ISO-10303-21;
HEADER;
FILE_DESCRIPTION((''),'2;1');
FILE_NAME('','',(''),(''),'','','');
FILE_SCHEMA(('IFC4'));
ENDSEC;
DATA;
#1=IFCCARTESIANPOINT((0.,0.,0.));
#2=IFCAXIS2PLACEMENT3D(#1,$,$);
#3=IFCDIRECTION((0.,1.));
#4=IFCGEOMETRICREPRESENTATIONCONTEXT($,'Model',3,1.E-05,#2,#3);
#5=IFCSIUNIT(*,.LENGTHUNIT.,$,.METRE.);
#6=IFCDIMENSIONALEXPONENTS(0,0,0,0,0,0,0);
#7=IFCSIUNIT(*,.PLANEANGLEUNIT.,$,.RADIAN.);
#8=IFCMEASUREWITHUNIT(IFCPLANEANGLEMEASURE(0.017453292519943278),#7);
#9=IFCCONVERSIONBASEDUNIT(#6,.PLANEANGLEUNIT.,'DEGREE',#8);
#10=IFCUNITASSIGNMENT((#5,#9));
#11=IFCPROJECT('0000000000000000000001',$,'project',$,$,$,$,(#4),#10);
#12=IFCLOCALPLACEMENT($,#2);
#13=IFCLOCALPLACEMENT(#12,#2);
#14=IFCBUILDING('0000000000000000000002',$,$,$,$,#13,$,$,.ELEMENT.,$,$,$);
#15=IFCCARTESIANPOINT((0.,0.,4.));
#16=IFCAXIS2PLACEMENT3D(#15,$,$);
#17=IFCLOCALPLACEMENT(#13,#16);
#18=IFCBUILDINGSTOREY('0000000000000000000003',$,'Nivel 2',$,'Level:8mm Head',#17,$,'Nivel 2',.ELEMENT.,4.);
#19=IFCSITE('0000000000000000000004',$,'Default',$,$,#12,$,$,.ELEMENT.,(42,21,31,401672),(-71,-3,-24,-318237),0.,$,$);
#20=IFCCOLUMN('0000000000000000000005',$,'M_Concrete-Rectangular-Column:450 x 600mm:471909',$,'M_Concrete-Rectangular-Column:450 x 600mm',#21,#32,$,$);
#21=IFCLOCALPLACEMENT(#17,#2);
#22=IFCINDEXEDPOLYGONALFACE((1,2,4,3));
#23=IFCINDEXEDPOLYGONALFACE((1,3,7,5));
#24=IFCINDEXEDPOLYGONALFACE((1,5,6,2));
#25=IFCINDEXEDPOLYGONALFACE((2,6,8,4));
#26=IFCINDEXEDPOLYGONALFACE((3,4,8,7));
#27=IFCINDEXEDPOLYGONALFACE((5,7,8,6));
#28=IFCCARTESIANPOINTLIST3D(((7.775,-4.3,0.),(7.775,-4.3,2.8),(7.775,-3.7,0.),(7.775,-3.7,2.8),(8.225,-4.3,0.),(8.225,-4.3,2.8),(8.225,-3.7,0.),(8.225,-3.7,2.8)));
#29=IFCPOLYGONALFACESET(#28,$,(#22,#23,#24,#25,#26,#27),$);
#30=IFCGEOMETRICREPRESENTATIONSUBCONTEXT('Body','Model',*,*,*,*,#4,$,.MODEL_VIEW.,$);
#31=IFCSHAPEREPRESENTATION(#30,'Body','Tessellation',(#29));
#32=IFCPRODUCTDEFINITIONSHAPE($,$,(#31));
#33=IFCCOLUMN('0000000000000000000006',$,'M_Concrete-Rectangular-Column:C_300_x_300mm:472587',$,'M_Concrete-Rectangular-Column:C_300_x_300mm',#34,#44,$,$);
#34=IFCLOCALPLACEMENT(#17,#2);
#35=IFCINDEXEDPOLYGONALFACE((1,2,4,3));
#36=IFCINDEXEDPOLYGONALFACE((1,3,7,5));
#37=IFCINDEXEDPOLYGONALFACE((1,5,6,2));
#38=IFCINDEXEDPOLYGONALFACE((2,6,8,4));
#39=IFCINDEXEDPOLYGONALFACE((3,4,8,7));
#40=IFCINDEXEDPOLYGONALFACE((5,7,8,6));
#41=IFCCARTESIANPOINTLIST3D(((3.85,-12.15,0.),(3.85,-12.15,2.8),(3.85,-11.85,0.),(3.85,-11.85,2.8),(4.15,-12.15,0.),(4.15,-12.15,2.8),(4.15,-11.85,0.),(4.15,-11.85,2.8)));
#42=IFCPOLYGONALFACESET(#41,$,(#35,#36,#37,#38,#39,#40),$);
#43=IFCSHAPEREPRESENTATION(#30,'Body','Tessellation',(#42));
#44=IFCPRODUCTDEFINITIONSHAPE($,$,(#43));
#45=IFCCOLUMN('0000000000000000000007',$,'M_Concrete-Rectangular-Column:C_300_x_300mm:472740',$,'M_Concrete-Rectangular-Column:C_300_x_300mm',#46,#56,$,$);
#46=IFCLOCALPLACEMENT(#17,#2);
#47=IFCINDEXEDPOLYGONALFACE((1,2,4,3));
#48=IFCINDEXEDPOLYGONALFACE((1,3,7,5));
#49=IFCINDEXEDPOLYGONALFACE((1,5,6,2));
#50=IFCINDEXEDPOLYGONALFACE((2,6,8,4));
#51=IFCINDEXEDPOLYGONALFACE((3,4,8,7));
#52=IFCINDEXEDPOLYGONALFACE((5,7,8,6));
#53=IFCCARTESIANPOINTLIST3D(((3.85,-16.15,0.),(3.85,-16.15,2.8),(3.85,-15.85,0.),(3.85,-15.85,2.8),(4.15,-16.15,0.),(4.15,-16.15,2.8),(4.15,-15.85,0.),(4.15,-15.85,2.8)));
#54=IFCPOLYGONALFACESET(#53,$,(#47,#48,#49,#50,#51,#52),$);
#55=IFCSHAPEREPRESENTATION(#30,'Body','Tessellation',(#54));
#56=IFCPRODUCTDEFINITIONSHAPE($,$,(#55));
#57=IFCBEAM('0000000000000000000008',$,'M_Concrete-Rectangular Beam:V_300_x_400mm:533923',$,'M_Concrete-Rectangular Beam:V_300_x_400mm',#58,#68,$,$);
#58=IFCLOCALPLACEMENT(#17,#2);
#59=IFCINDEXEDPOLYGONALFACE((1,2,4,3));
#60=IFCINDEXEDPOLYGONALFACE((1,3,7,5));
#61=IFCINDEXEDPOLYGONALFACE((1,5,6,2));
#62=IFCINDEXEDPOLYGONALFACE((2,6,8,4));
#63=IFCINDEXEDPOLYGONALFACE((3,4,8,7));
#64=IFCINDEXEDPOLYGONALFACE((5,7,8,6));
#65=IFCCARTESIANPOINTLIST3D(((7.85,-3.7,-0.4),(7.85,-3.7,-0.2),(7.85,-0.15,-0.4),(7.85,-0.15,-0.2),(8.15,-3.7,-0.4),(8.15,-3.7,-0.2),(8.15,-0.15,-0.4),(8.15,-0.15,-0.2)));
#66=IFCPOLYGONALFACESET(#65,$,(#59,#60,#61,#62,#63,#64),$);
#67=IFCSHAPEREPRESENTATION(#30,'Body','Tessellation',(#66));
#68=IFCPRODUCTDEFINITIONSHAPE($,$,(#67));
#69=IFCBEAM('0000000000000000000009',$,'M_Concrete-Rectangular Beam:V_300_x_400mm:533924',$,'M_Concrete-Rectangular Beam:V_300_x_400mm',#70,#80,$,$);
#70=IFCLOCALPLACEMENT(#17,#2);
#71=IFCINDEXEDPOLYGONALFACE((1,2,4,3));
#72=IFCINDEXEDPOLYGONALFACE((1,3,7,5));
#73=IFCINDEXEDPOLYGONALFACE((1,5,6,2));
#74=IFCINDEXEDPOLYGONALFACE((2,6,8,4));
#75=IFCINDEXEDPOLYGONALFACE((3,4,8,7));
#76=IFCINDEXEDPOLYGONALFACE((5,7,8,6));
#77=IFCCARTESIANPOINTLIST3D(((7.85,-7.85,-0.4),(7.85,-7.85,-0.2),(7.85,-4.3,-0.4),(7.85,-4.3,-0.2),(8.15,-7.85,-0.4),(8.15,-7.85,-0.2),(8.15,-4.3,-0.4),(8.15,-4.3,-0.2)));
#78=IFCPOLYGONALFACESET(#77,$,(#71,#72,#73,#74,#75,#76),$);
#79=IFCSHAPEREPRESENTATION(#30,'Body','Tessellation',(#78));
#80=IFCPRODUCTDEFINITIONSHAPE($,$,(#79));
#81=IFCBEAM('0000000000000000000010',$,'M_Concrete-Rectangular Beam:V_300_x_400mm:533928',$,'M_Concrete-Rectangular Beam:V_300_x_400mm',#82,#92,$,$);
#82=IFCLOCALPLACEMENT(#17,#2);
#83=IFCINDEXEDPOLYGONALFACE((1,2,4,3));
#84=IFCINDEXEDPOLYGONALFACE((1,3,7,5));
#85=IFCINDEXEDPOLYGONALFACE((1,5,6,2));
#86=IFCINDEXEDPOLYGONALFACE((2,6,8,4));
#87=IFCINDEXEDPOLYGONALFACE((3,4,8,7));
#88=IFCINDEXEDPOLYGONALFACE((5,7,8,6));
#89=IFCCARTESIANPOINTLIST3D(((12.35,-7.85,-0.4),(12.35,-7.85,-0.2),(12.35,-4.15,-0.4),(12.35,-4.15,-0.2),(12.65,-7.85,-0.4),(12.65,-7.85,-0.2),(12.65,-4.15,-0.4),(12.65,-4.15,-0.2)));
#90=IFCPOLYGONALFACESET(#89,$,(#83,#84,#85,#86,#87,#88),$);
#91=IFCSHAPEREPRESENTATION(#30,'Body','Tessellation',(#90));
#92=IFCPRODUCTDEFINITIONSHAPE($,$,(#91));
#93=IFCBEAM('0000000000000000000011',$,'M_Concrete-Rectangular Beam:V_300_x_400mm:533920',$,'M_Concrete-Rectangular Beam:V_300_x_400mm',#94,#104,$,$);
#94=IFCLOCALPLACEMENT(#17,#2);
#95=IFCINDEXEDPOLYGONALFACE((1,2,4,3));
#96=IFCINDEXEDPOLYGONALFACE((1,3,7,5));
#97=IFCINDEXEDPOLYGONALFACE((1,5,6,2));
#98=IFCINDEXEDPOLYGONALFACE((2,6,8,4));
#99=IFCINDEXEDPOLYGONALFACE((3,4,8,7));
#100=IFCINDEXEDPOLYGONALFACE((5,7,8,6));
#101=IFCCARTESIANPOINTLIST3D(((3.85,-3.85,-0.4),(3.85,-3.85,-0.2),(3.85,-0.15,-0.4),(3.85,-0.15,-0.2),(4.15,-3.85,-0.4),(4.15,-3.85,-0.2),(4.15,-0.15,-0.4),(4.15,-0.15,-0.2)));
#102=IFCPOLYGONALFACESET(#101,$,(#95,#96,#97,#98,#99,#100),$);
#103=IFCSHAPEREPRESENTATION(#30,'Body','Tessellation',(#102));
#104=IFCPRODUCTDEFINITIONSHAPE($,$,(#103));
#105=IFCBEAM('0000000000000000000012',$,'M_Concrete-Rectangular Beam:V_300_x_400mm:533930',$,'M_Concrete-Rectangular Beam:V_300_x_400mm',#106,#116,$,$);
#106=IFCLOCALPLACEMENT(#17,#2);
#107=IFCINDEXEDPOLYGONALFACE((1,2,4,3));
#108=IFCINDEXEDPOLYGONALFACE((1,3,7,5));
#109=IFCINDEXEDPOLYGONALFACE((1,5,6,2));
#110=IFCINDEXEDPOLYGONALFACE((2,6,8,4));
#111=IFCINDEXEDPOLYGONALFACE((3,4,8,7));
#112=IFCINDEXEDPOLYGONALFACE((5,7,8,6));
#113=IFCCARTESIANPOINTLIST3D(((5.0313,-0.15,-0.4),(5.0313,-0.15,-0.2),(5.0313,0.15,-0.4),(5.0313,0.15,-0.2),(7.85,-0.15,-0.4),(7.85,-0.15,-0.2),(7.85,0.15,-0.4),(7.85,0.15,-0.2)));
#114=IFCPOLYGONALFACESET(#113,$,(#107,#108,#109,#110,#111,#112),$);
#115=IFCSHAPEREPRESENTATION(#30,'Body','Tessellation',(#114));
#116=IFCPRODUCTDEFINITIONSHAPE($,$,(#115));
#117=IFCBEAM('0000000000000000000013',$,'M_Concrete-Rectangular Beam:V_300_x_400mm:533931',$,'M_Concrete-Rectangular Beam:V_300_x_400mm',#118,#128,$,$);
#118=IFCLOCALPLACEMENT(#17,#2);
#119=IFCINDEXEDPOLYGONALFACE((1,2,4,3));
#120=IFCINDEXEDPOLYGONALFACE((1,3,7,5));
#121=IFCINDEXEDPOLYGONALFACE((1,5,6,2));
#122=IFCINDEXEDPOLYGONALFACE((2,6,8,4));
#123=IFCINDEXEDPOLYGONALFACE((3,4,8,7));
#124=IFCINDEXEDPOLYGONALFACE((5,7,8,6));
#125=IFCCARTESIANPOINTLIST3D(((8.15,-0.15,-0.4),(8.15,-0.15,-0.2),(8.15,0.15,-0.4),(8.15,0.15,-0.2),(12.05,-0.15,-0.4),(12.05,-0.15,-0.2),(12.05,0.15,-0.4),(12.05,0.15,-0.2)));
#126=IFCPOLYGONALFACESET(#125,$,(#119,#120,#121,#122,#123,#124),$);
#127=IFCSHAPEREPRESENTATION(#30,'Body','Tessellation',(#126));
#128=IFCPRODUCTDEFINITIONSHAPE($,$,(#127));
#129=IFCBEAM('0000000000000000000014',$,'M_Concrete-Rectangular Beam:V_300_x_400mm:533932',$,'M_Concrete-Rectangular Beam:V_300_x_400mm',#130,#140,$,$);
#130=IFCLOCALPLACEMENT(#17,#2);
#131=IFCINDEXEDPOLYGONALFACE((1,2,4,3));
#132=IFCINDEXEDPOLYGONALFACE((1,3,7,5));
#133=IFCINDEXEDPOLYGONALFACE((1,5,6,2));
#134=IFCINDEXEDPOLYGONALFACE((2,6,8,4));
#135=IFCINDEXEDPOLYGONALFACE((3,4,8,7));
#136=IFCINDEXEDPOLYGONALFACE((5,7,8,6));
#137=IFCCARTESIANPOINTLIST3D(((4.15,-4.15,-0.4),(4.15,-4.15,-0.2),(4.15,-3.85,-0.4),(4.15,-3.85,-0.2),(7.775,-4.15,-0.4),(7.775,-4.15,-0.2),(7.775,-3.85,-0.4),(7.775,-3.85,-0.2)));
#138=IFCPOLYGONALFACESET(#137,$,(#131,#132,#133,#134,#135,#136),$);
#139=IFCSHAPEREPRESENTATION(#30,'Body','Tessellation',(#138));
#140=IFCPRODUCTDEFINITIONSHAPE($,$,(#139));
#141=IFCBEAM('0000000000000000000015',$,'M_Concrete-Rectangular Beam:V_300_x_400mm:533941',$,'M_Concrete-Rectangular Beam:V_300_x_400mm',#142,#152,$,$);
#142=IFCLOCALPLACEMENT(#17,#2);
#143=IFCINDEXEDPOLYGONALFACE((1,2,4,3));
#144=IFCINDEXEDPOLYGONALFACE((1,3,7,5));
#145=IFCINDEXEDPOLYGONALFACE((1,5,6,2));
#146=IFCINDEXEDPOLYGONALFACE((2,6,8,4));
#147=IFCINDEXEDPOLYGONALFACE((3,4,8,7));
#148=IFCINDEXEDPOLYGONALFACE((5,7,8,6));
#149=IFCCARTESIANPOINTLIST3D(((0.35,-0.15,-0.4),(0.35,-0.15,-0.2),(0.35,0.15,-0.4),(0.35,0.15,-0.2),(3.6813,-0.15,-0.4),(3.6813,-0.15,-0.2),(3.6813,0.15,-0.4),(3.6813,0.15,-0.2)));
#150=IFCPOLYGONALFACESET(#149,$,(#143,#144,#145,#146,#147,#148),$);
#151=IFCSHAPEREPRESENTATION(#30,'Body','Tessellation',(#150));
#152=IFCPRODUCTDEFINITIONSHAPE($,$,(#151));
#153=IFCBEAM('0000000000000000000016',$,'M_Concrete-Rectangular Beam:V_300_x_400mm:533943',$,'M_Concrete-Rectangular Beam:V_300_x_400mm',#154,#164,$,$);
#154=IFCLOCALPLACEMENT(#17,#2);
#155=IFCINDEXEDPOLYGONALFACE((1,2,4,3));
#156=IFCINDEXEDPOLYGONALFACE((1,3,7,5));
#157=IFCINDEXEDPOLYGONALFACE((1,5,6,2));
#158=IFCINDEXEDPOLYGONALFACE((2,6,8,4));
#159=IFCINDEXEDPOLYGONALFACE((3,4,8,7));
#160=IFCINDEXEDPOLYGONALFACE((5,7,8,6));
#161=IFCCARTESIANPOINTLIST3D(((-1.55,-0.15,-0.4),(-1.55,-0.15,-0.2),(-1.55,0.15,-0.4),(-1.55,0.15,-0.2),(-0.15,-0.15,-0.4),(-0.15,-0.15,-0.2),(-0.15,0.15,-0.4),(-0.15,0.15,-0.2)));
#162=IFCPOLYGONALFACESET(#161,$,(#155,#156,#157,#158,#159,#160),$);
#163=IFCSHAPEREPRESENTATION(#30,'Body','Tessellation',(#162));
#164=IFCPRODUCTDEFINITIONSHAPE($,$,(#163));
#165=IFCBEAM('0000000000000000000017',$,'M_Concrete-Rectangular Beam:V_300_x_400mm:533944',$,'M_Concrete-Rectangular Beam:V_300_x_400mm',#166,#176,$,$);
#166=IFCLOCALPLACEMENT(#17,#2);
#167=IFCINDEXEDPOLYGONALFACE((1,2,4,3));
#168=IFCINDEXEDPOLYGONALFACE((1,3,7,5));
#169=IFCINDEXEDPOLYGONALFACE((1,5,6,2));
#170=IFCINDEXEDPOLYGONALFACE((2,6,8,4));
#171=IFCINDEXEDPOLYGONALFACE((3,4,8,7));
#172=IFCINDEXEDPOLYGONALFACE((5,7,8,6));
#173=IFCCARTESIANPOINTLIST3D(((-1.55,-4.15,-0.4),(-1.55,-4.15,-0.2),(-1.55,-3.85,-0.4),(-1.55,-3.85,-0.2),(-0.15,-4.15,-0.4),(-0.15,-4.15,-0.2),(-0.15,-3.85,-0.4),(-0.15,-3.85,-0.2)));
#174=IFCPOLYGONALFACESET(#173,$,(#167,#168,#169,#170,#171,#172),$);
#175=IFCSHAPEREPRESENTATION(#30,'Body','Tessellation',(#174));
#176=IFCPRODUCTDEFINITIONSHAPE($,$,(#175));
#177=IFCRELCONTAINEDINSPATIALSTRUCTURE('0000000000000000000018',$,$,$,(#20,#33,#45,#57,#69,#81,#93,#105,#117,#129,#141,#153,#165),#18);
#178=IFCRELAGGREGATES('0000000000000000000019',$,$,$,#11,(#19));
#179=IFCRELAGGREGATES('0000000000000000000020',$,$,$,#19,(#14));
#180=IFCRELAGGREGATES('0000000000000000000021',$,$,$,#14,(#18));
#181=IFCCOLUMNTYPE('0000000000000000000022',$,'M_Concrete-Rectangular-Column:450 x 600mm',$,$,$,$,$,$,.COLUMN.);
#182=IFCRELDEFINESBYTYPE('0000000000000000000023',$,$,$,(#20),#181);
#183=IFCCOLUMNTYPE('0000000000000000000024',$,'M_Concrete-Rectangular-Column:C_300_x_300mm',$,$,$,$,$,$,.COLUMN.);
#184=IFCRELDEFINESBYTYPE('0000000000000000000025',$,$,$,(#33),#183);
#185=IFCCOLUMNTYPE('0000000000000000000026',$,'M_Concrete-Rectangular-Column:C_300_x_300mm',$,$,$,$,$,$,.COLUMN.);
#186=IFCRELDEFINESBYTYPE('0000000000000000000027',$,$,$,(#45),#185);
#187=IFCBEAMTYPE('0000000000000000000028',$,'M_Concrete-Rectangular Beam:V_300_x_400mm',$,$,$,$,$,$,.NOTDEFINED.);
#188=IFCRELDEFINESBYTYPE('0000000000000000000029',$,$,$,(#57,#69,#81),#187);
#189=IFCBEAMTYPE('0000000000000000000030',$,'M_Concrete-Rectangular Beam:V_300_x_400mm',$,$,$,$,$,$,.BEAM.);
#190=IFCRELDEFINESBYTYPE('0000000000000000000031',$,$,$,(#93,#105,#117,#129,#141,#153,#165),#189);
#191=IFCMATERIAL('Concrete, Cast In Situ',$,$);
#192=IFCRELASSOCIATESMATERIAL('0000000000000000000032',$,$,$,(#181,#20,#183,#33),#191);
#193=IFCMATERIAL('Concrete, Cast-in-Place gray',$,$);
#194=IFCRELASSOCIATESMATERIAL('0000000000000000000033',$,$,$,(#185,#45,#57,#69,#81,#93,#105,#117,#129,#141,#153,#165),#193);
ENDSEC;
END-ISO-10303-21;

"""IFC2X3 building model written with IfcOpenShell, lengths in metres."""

from ifc_helpers import new_model, entity, si_unit, converted_unit, direction, frame, frame_2d, origin, place, context, subcontext, project, spatial, rectangle, extrude, source, transform, mapped, material, type_object, type_shapes, element, save


model = new_model("IFC2X3")

# Units and contexts
model_context = context("Model", 3, precision=1e-05, world=origin(), true_north=direction((0.0, 1.0)))
body_context = subcontext(model_context, "Body", "Model", "MODEL_VIEW")
ifc_project = project(units=[si_unit("LENGTHUNIT", "METRE"), converted_unit("PLANEANGLEUNIT", "DEGREE", entity("IfcPlaneAngleMeasure", 0.017453292519943278), si_unit("PLANEANGLEUNIT", "RADIAN"), dimensions=[0, 0, 0, 0, 0, 0, 0])], contexts=[model_context])

# Site, building, storey
site_placement = place(None, origin())
site = spatial("IfcSite", under=ifc_project, at=site_placement, Name="Default", CompositionType="ELEMENT", RefLatitude=(42, 21, 31, 401672), RefLongitude=(-71, -3, -24, -318237), RefElevation=0.0)
building_placement = place(site_placement, origin())
building = spatial("IfcBuilding", under=site, at=building_placement, CompositionType="ELEMENT")
storey_placement = place(building_placement, frame((0.0, 0.0, 4.0)))
storey = spatial("IfcBuildingStorey", under=building, at=storey_placement, Name="Nivel 2", ObjectType="Level:8mm Head", LongName="Nivel 2", CompositionType="ELEMENT", Elevation=4.0)

# Columns
ifc_material_1 = material(Name="Concrete, Cast-in-Place gray")
ifc_material_2 = material(Name="Concrete, Cast In Situ")
column_type_1 = type_object("IfcColumnType", Name="M_Concrete-Rectangular-Column:450 x 600mm", PredefinedType="COLUMN", material=ifc_material_2)
shared_shape_1 = source(origin(), body_context, "Body", "SweptSolid", [
    extrude(rectangle(XDim=2.8, YDim=0.6, at=frame_2d((0.0, 0.0), x_axis=(1.0, 0.0))), frame((7.775, -4.0, 5.4), z_axis=(1.0, 0.0, 0.0), x_axis=(0.0, 0.0, 1.0)), (0.0, 0.0, 1.0), 0.45),
])
type_shapes(column_type_1, [shared_shape_1])
column_1_placement = place(storey_placement, frame((0.0, 0.0, -4.0)))
element("IfcColumn", 1, at=column_1_placement, inside=storey, type_object=column_type_1, material=ifc_material_2, Name="M_Concrete-Rectangular-Column:450 x 600mm:471909", ObjectType="M_Concrete-Rectangular-Column:450 x 600mm", context=body_context, shape_type="MappedRepresentation", body=[
    mapped(shared_shape_1, transform((0.0, 0.0, 0.0), scale=1.0)),
])
column_type_2 = type_object("IfcColumnType", Name="M_Concrete-Rectangular-Column:C_300_x_300mm", PredefinedType="COLUMN", material=ifc_material_2)
shared_shape_2 = source(origin(), body_context, "Body", "SweptSolid", [
    extrude(rectangle(XDim=0.3, YDim=0.3, at=frame_2d((0.0, 0.0), x_axis=(1.0, 0.0))), frame((4.0, -12.0, 4.0), z_axis=(0.0, 0.0, 1.0), x_axis=(-1.0, 0.0, 0.0)), (0.0, 0.0, 1.0), 2.8),
])
type_shapes(column_type_2, [shared_shape_2])
column_2_placement = place(storey_placement, frame((0.0, 0.0, -4.0)))
element("IfcColumn", 2, at=column_2_placement, inside=storey, type_object=column_type_2, material=ifc_material_2, Name="M_Concrete-Rectangular-Column:C_300_x_300mm:472587", ObjectType="M_Concrete-Rectangular-Column:C_300_x_300mm", context=body_context, shape_type="MappedRepresentation", body=[
    mapped(shared_shape_2, transform((0.0, 0.0, 0.0), scale=1.0)),
])
column_type_3 = type_object("IfcColumnType", Name="M_Concrete-Rectangular-Column:C_300_x_300mm", PredefinedType="COLUMN", material=ifc_material_1)
shared_shape_3 = source(origin(), body_context, "Body", "SweptSolid", [
    extrude(rectangle(XDim=0.3, YDim=0.3, at=frame_2d((0.0, 0.0), x_axis=(1.0, 0.0))), frame((4.0, -16.0, 4.0), z_axis=(0.0, 0.0, 1.0), x_axis=(-1.0, 0.0, 0.0)), (0.0, 0.0, 1.0), 2.8),
])
type_shapes(column_type_3, [shared_shape_3])
column_3_placement = place(storey_placement, frame((0.0, 0.0, -4.0)))
element("IfcColumn", 3, at=column_3_placement, inside=storey, type_object=column_type_3, material=ifc_material_1, Name="M_Concrete-Rectangular-Column:C_300_x_300mm:472740", ObjectType="M_Concrete-Rectangular-Column:C_300_x_300mm", context=body_context, shape_type="MappedRepresentation", body=[
    mapped(shared_shape_3, transform((0.0, 0.0, 0.0), scale=1.0)),
])

# Beams
beam_type_1 = type_object("IfcBeamType", Name="M_Concrete-Rectangular Beam:V_300_x_400mm", PredefinedType="NOTDEFINED")
beam_1_placement = place(storey_placement, frame((8.0, 0.0, 0.0), z_axis=(0.0, 0.0, 1.0), x_axis=(0.0, -1.0, 0.0)))
element("IfcBeam", 4, at=beam_1_placement, inside=storey, type_object=beam_type_1, material=ifc_material_1, Name="M_Concrete-Rectangular Beam:V_300_x_400mm:533923", ObjectType="M_Concrete-Rectangular Beam:V_300_x_400mm", context=body_context, shape_type="SweptSolid", body=[
    extrude(rectangle(XDim=0.2, YDim=0.3, at=frame_2d((0.0, 0.0), x_axis=(1.0, 0.0))), frame((0.15, 0.0, -0.3), z_axis=(1.0, 0.0, 0.0), x_axis=(0.0, 0.0, -1.0)), (0.0, 0.0, 1.0), 3.55),
])
beam_2_placement = place(storey_placement, frame((8.0, -4.0, 0.0), z_axis=(0.0, 0.0, 1.0), x_axis=(0.0, -1.0, 0.0)))
element("IfcBeam", 5, at=beam_2_placement, inside=storey, type_object=beam_type_1, material=ifc_material_1, Name="M_Concrete-Rectangular Beam:V_300_x_400mm:533924", ObjectType="M_Concrete-Rectangular Beam:V_300_x_400mm", context=body_context, shape_type="SweptSolid", body=[
    extrude(rectangle(XDim=0.2, YDim=0.3, at=frame_2d((0.0, 0.0), x_axis=(1.0, 0.0))), frame((0.3, 0.0, -0.3), z_axis=(1.0, 0.0, 0.0), x_axis=(0.0, 0.0, -1.0)), (0.0, 0.0, 1.0), 3.55),
])
beam_3_placement = place(storey_placement, frame((12.5, -4.0, 0.0), z_axis=(0.0, 0.0, 1.0), x_axis=(0.0, -1.0, 0.0)))
element("IfcBeam", 6, at=beam_3_placement, inside=storey, type_object=beam_type_1, material=ifc_material_1, Name="M_Concrete-Rectangular Beam:V_300_x_400mm:533928", ObjectType="M_Concrete-Rectangular Beam:V_300_x_400mm", context=body_context, shape_type="SweptSolid", body=[
    extrude(rectangle(XDim=0.2, YDim=0.3, at=frame_2d((0.0, 0.0), x_axis=(1.0, 0.0))), frame((0.15, 0.0, -0.3), z_axis=(1.0, 0.0, 0.0), x_axis=(0.0, 0.0, -1.0)), (0.0, 0.0, 1.0), 3.7),
])
beam_type_2 = type_object("IfcBeamType", Name="M_Concrete-Rectangular Beam:V_300_x_400mm", PredefinedType="BEAM")
beam_4_placement = place(storey_placement, frame((4.0, 0.0, 0.0), z_axis=(0.0, 0.0, 1.0), x_axis=(0.0, -1.0, 0.0)))
element("IfcBeam", 7, at=beam_4_placement, inside=storey, type_object=beam_type_2, material=ifc_material_1, Name="M_Concrete-Rectangular Beam:V_300_x_400mm:533920", ObjectType="M_Concrete-Rectangular Beam:V_300_x_400mm", context=body_context, shape_type="SweptSolid", body=[
    extrude(rectangle(XDim=0.2, YDim=0.3, at=frame_2d((0.0, 0.0), x_axis=(1.0, 0.0))), frame((0.15, 0.0, -0.3), z_axis=(1.0, 0.0, 0.0), x_axis=(0.0, 0.0, -1.0)), (0.0, 0.0, 1.0), 3.7),
])
beam_5_placement = place(storey_placement, frame((5.0313, 0.0, 0.0)))
element("IfcBeam", 8, at=beam_5_placement, inside=storey, type_object=beam_type_2, material=ifc_material_1, Name="M_Concrete-Rectangular Beam:V_300_x_400mm:533930", ObjectType="M_Concrete-Rectangular Beam:V_300_x_400mm", context=body_context, shape_type="SweptSolid", body=[
    extrude(rectangle(XDim=0.2, YDim=0.3, at=frame_2d((0.0, 0.0), x_axis=(1.0, 0.0))), frame((0.0, 0.0, -0.3), z_axis=(1.0, 0.0, 0.0), x_axis=(0.0, 0.0, -1.0)), (0.0, 0.0, 1.0), 2.8187),
])
beam_6_placement = place(storey_placement, frame((8.0, 0.0, 0.0)))
element("IfcBeam", 9, at=beam_6_placement, inside=storey, type_object=beam_type_2, material=ifc_material_1, Name="M_Concrete-Rectangular Beam:V_300_x_400mm:533931", ObjectType="M_Concrete-Rectangular Beam:V_300_x_400mm", context=body_context, shape_type="SweptSolid", body=[
    extrude(rectangle(XDim=0.2, YDim=0.3, at=frame_2d((0.0, 0.0), x_axis=(1.0, 0.0))), frame((0.15, 0.0, -0.3), z_axis=(1.0, 0.0, 0.0), x_axis=(0.0, 0.0, -1.0)), (0.0, 0.0, 1.0), 3.9),
])
beam_7_placement = place(storey_placement, frame((4.0, -4.0, 0.0)))
element("IfcBeam", 10, at=beam_7_placement, inside=storey, type_object=beam_type_2, material=ifc_material_1, Name="M_Concrete-Rectangular Beam:V_300_x_400mm:533932", ObjectType="M_Concrete-Rectangular Beam:V_300_x_400mm", context=body_context, shape_type="SweptSolid", body=[
    extrude(rectangle(XDim=0.2, YDim=0.3, at=frame_2d((0.0, 0.0), x_axis=(1.0, 0.0))), frame((0.15, 0.0, -0.3), z_axis=(1.0, 0.0, 0.0), x_axis=(0.0, 0.0, -1.0)), (0.0, 0.0, 1.0), 3.625),
])
beam_8_placement = place(storey_placement, frame((-0.05, 0.0, 0.0)))
element("IfcBeam", 11, at=beam_8_placement, inside=storey, type_object=beam_type_2, material=ifc_material_1, Name="M_Concrete-Rectangular Beam:V_300_x_400mm:533941", ObjectType="M_Concrete-Rectangular Beam:V_300_x_400mm", context=body_context, shape_type="SweptSolid", body=[
    extrude(rectangle(XDim=0.2, YDim=0.3, at=frame_2d((0.0, 0.0), x_axis=(1.0, 0.0))), frame((0.4, 0.0, -0.3), z_axis=(1.0, 0.0, 0.0), x_axis=(0.0, 0.0, -1.0)), (0.0, 0.0, 1.0), 3.3313),
])
beam_9_placement = place(storey_placement, frame((-0.05, 0.0, 0.0), z_axis=(0.0, 0.0, 1.0), x_axis=(-1.0, 0.0, 0.0)))
element("IfcBeam", 12, at=beam_9_placement, inside=storey, type_object=beam_type_2, material=ifc_material_1, Name="M_Concrete-Rectangular Beam:V_300_x_400mm:533943", ObjectType="M_Concrete-Rectangular Beam:V_300_x_400mm", context=body_context, shape_type="SweptSolid", body=[
    extrude(rectangle(XDim=0.2, YDim=0.3, at=frame_2d((0.0, 0.0), x_axis=(1.0, 0.0))), frame((0.1, 0.0, -0.3), z_axis=(1.0, 0.0, 0.0), x_axis=(0.0, 0.0, -1.0)), (0.0, 0.0, 1.0), 1.4),
])
beam_10_placement = place(storey_placement, frame((-0.05, -4.0, 0.0), z_axis=(0.0, 0.0, 1.0), x_axis=(-1.0, 0.0, 0.0)))
element("IfcBeam", 13, at=beam_10_placement, inside=storey, type_object=beam_type_2, material=ifc_material_1, Name="M_Concrete-Rectangular Beam:V_300_x_400mm:533944", ObjectType="M_Concrete-Rectangular Beam:V_300_x_400mm", context=body_context, shape_type="SweptSolid", body=[
    extrude(rectangle(XDim=0.2, YDim=0.3, at=frame_2d((0.0, 0.0), x_axis=(1.0, 0.0))), frame((0.1, 0.0, -0.3), z_axis=(1.0, 0.0, 0.0), x_axis=(0.0, 0.0, -1.0)), (0.0, 0.0, 1.0), 1.4),
])

save(model, "model.ifc")
